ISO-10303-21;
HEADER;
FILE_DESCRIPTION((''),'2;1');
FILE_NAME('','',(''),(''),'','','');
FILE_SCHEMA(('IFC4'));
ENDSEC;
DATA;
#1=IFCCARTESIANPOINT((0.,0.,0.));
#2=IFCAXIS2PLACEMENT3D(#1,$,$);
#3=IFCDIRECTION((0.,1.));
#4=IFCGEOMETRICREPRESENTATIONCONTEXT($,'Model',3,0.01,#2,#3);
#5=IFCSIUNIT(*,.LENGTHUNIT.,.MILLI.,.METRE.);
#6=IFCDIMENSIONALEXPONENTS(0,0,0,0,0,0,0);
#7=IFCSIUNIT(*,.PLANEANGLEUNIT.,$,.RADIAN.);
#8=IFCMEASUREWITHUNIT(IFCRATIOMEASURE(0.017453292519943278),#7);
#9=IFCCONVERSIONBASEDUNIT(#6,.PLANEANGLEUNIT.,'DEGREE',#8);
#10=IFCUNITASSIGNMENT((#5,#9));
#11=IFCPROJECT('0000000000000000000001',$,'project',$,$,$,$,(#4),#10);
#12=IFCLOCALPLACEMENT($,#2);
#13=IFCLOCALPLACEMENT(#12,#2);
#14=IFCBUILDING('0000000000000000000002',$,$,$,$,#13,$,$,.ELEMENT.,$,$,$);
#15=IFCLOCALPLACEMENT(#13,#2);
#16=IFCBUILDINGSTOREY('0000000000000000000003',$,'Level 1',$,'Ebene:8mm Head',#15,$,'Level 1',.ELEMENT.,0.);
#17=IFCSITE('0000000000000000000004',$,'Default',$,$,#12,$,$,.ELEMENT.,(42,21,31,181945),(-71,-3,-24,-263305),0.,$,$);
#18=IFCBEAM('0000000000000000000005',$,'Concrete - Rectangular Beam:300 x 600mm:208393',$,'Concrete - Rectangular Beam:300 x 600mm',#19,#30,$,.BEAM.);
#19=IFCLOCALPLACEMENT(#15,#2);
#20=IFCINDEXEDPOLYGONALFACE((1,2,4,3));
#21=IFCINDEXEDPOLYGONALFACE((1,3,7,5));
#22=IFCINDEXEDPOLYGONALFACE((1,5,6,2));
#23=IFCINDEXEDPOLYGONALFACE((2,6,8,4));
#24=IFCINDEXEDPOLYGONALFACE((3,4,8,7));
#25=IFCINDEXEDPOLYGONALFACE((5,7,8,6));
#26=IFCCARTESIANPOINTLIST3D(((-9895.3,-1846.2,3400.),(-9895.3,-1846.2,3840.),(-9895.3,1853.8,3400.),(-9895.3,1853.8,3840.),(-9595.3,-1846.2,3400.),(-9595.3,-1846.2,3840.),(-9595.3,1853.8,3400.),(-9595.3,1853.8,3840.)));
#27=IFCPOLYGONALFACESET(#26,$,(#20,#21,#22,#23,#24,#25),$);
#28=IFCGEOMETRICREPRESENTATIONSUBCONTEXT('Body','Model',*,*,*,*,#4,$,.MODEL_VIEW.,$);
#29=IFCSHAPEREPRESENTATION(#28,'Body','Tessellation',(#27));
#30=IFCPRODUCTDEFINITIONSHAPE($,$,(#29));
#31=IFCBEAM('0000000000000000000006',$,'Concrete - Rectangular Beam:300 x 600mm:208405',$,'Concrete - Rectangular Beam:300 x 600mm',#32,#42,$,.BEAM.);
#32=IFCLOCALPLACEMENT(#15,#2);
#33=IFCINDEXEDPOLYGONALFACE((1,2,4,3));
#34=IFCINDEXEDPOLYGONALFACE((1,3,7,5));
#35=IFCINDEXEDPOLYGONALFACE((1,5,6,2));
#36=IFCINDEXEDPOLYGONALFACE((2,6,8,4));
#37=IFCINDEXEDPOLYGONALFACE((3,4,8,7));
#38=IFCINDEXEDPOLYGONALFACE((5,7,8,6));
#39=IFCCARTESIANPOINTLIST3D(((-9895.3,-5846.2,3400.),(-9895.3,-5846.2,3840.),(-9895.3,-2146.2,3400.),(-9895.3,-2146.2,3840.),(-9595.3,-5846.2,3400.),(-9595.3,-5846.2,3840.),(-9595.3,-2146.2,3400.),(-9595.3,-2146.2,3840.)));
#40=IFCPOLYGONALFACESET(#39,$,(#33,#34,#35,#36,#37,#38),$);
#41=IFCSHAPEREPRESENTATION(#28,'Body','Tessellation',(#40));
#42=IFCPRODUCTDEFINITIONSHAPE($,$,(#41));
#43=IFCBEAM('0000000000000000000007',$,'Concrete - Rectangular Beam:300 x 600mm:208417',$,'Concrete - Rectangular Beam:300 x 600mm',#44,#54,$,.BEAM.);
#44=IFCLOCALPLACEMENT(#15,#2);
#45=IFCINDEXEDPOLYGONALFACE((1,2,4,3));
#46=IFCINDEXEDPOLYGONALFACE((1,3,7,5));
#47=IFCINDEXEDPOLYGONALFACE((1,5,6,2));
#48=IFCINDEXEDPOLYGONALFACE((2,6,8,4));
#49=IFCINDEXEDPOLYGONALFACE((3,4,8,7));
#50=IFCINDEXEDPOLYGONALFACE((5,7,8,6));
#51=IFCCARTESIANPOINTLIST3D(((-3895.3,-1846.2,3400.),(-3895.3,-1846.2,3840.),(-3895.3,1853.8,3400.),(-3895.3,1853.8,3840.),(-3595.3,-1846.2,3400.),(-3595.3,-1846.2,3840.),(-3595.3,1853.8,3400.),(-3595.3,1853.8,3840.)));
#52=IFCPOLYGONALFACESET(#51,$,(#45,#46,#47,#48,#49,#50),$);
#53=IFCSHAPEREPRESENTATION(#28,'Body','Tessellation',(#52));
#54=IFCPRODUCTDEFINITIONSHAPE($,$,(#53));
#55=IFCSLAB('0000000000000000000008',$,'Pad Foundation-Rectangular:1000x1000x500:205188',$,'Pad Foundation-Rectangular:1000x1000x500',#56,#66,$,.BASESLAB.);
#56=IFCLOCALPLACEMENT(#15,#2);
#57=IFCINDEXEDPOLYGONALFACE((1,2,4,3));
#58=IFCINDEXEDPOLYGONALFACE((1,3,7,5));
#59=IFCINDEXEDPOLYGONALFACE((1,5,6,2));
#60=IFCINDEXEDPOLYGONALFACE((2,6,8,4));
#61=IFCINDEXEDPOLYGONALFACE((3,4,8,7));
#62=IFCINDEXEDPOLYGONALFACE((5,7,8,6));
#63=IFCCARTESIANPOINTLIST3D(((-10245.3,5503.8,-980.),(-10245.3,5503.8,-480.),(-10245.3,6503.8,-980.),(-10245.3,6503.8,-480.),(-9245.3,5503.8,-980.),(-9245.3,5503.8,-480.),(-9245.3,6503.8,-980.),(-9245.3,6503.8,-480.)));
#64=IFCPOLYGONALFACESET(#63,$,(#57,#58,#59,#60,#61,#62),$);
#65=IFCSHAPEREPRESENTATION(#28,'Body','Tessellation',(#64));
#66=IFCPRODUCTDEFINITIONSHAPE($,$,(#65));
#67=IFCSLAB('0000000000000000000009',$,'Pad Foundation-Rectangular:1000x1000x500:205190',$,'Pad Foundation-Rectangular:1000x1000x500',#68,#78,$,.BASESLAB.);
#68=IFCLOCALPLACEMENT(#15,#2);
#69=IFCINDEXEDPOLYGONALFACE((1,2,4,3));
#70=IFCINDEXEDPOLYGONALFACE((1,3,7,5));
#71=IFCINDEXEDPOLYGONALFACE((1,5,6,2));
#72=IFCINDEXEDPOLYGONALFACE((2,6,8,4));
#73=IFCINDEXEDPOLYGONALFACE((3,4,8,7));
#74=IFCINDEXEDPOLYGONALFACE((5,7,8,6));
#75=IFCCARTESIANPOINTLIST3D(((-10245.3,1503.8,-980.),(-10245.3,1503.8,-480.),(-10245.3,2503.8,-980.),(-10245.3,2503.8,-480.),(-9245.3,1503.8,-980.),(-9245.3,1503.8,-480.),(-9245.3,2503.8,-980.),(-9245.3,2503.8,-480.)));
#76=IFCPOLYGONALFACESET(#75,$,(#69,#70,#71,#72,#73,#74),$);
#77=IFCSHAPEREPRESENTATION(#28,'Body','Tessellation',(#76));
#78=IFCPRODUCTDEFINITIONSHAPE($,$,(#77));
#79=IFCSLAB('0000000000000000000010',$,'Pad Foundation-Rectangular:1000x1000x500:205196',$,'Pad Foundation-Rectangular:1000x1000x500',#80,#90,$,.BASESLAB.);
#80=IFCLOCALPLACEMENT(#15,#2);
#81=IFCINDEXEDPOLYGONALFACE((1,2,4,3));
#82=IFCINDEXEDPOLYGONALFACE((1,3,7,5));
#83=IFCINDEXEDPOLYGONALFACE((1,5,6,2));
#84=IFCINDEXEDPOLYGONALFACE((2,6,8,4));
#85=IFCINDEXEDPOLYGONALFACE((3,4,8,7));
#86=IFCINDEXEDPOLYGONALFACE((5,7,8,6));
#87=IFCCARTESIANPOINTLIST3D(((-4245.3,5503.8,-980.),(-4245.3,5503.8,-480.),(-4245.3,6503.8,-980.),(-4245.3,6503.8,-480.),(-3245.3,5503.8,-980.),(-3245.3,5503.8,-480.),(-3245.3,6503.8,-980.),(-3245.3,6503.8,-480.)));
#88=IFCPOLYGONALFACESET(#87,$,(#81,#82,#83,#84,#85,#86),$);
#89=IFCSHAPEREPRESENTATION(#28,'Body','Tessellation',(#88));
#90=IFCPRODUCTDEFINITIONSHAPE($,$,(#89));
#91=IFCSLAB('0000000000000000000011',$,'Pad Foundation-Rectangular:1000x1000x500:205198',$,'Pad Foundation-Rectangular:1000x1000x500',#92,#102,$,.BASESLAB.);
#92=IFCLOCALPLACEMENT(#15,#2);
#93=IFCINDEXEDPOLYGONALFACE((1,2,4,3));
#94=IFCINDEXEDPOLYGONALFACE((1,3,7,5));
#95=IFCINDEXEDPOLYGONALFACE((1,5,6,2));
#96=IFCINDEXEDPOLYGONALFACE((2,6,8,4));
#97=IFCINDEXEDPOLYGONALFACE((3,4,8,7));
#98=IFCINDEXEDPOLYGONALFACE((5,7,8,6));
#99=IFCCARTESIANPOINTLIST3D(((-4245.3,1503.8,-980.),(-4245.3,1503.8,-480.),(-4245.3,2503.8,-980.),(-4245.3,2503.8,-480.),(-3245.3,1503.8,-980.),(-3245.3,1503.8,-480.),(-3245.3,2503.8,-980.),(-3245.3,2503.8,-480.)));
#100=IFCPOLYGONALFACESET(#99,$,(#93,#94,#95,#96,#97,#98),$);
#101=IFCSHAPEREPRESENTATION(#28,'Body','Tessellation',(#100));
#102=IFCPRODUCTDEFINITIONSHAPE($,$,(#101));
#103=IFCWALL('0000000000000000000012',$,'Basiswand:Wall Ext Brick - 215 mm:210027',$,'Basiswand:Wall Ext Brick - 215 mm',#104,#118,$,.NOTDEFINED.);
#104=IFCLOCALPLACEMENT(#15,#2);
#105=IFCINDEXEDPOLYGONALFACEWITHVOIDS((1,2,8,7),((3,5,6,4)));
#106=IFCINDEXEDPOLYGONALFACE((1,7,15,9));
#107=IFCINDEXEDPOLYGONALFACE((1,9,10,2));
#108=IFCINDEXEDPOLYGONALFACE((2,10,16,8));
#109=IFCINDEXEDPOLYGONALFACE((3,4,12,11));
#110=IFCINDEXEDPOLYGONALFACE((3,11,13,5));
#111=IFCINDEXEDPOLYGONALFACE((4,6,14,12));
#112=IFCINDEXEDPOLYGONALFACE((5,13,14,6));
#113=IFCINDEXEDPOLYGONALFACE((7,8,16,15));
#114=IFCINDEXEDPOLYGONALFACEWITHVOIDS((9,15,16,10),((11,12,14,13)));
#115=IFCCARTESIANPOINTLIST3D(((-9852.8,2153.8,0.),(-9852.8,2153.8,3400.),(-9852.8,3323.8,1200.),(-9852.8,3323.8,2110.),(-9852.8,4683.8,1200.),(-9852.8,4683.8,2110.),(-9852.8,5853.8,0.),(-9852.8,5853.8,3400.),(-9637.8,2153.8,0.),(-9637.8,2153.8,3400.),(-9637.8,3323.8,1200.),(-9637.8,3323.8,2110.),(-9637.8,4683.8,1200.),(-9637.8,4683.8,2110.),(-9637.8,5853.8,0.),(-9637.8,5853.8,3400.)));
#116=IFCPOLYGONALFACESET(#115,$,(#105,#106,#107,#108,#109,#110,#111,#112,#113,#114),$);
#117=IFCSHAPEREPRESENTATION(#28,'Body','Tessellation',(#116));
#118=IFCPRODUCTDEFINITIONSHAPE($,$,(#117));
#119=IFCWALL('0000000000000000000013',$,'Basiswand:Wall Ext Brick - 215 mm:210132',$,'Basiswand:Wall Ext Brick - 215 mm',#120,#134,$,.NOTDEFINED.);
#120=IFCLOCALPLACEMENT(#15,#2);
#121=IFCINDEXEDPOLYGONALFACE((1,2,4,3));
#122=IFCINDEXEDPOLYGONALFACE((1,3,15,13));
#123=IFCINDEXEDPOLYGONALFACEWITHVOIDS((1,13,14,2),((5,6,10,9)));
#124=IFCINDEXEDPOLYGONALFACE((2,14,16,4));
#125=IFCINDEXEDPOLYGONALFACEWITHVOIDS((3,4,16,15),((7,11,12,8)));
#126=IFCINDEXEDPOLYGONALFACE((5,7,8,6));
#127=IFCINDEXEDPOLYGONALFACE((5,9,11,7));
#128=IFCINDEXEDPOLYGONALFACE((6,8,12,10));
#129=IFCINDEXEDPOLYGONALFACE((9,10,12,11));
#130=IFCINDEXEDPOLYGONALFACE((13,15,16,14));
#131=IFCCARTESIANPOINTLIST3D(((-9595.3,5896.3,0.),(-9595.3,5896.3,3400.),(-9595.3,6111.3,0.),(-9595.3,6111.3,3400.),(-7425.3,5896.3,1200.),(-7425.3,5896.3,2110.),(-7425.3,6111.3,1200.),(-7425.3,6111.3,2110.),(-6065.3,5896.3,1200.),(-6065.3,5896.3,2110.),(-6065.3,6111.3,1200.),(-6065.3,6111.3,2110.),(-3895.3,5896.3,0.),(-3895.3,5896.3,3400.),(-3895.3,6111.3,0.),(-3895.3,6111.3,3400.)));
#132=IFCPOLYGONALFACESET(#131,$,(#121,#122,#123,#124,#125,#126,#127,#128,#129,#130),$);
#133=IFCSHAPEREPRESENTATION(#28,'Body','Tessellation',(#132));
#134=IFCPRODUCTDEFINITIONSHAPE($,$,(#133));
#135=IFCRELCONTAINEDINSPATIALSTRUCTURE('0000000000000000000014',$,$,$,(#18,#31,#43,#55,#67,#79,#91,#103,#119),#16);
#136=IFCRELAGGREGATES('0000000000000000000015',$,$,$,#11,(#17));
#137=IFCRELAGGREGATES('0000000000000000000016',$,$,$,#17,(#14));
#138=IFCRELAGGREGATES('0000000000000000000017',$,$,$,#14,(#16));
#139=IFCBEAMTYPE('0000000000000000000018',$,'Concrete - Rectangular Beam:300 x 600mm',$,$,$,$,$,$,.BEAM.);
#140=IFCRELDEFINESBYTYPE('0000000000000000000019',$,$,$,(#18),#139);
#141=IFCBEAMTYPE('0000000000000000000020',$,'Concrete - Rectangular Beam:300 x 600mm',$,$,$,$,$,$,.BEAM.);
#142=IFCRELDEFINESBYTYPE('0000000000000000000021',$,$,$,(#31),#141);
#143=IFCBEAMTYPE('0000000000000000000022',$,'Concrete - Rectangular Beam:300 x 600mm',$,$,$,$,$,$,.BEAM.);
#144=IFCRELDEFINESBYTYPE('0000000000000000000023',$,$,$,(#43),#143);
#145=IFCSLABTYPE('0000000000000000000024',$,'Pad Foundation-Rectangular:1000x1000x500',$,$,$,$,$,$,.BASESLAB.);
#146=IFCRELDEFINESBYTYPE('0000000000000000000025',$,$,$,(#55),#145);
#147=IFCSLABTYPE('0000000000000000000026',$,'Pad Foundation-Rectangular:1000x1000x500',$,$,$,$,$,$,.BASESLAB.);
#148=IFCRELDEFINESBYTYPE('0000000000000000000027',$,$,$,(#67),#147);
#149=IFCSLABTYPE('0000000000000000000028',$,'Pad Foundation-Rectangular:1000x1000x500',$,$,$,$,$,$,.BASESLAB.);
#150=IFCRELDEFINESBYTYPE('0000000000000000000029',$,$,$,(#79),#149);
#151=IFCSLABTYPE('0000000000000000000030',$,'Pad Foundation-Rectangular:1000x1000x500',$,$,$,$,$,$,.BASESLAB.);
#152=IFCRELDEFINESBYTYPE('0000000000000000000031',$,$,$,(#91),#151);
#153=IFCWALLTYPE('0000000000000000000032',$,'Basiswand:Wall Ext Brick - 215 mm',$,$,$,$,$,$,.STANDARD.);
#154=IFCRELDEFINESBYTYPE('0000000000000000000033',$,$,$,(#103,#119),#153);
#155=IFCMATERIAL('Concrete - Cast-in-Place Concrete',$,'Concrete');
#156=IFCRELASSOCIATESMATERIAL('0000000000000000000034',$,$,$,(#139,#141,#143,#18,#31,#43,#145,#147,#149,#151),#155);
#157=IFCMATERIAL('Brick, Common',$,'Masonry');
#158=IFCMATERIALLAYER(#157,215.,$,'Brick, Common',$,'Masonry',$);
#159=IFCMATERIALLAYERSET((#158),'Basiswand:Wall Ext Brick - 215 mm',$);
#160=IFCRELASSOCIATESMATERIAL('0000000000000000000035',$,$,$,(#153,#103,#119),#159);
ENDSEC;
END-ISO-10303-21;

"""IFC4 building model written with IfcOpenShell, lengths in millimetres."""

from ifc_helpers import new_model, entity, si_unit, converted_unit, direction, frame, frame_2d, origin, origin_2d_with_axis, place, context, subcontext, project, spatial, polyline, segment, composite_curve, rectangle, outline, extrude, source, transform, mapped, material, layer, layer_set, layer_usage, material_profile, profile_set, profile_usage, type_object, type_shapes, element, save


model = new_model("IFC4")

# Units and contexts
model_context = context("Model", 3, precision=0.01, world=origin(), true_north=direction((0.0, 1.0)))
body_context = subcontext(model_context, "Body", "Model", "MODEL_VIEW")
ifc_project = project(units=[si_unit("LENGTHUNIT", "METRE", prefix="MILLI"), converted_unit("PLANEANGLEUNIT", "DEGREE", entity("IfcRatioMeasure", 0.017453292519943278), si_unit("PLANEANGLEUNIT", "RADIAN"), dimensions=[0, 0, 0, 0, 0, 0, 0])], contexts=[model_context])

# Site, building, storey
site_placement = place(None, origin())
site = spatial("IfcSite", under=ifc_project, at=site_placement, Name="Default", CompositionType="ELEMENT", RefLatitude=(42, 21, 31, 181945), RefLongitude=(-71, -3, -24, -263305), RefElevation=0.0)
building_placement = place(site_placement, origin())
building = spatial("IfcBuilding", under=site, at=building_placement, CompositionType="ELEMENT")
storey_placement = place(building_placement, origin())
storey = spatial("IfcBuildingStorey", under=building, at=storey_placement, Name="Level 1", ObjectType="Ebene:8mm Head", LongName="Level 1", CompositionType="ELEMENT", Elevation=0.0)

# Shared definitions
ifc_material_1 = material(Name="Concrete - Cast-in-Place Concrete", Category="Concrete")

# Beams
ifc_material_profile_1 = material_profile(ifc_material_1, outline(composite_curve([segment(polyline([(-150.0, -300.0, 0.0), (-150.0, 140.0, 0.0)]), True, "CONTINUOUS"), segment(polyline([(-150.0, 140.0, 0.0), (150.0, 140.0, 0.0)]), True, "CONTINUOUS"), segment(polyline([(150.0, 140.0, 0.0), (150.0, -300.0, 0.0)]), True, "CONTINUOUS"), segment(polyline([(150.0, -300.0, 0.0), (-150.0, -300.0, 0.0)]), True, "CONTINUOUS")], self_intersect=False), kind="CURVE"), Name="300 x 600mm")
ifc_material_profile_2 = material_profile(ifc_material_1, outline(composite_curve([segment(polyline([(1850.0, -150.0, -300.0), (1850.0, -150.0, 300.0)]), True, "CONTINUOUS"), segment(polyline([(1850.0, -150.0, 300.0), (-1850.0, -150.0, 300.0)]), True, "CONTINUOUS"), segment(polyline([(-1850.0, -150.0, 300.0), (-1850.0, -150.0, -300.0)]), True, "CONTINUOUS"), segment(polyline([(-1850.0, -150.0, -300.0), (1850.0, -150.0, -300.0)]), True, "CONTINUOUS")], self_intersect=False), kind="CURVE"), Name="300 x 600mm")
ifc_profile_set_1 = profile_set([ifc_material_profile_1, ifc_material_profile_2], Name="300 x 600mm")
ifc_profile_usage_1 = profile_usage(ifc_profile_set_1, cardinal=8)
beam_type_1 = type_object("IfcBeamType", Name="Concrete - Rectangular Beam:300 x 600mm", PredefinedType="BEAM", material=ifc_profile_set_1)
shared_shape_1 = source(origin(), body_context, "Body", "SweptSolid", [
    extrude(rectangle(XDim=440.0, YDim=300.0, at=frame_2d((0.0, 0.0), x_axis=(0.0, 1.0))), frame((-9745.3, 1853.8, 3620.0), z_axis=(0.0, -1.0, 0.0), x_axis=(-1.0, 0.0, 0.0)), (0.0, 0.0, 1.0), 3700.0),
])
type_shapes(beam_type_1, [shared_shape_1])
beam_1_placement = place(storey_placement, origin())
element("IfcBeam", 1, at=beam_1_placement, inside=storey, type_object=beam_type_1, material=ifc_profile_usage_1, Name="Concrete - Rectangular Beam:300 x 600mm:208393", ObjectType="Concrete - Rectangular Beam:300 x 600mm", PredefinedType="BEAM", context=body_context, shape_type="MappedRepresentation", body=[
    mapped(shared_shape_1, transform((0.0, 0.0, 0.0), scale=1.0)),
])
ifc_profile_usage_2 = profile_usage(ifc_profile_set_1, cardinal=8)
beam_type_2 = type_object("IfcBeamType", Name="Concrete - Rectangular Beam:300 x 600mm", PredefinedType="BEAM", material=ifc_profile_set_1)
shared_shape_2 = source(origin(), body_context, "Body", "SweptSolid", [
    extrude(rectangle(XDim=440.0, YDim=300.0, at=frame_2d((0.0, 0.0), x_axis=(0.0, 1.0))), frame((-9745.3, -2146.2, 3620.0), z_axis=(0.0, -1.0, 0.0), x_axis=(-1.0, 0.0, 0.0)), (0.0, 0.0, 1.0), 3700.0),
])
type_shapes(beam_type_2, [shared_shape_2])
beam_2_placement = place(storey_placement, origin())
element("IfcBeam", 2, at=beam_2_placement, inside=storey, type_object=beam_type_2, material=ifc_profile_usage_2, Name="Concrete - Rectangular Beam:300 x 600mm:208405", ObjectType="Concrete - Rectangular Beam:300 x 600mm", PredefinedType="BEAM", context=body_context, shape_type="MappedRepresentation", body=[
    mapped(shared_shape_2, transform((0.0, 0.0, 0.0), scale=1.0)),
])
ifc_profile_usage_3 = profile_usage(ifc_profile_set_1, cardinal=8)
beam_type_3 = type_object("IfcBeamType", Name="Concrete - Rectangular Beam:300 x 600mm", PredefinedType="BEAM", material=ifc_profile_set_1)
shared_shape_3 = source(origin(), body_context, "Body", "SweptSolid", [
    extrude(rectangle(XDim=440.0, YDim=300.0, at=frame_2d((0.0, 0.0), x_axis=(0.0, 1.0))), frame((-3745.3, 1853.8, 3620.0), z_axis=(0.0, -1.0, 0.0), x_axis=(-1.0, 0.0, 0.0)), (0.0, 0.0, 1.0), 3700.0),
])
type_shapes(beam_type_3, [shared_shape_3])
beam_3_placement = place(storey_placement, origin())
element("IfcBeam", 3, at=beam_3_placement, inside=storey, type_object=beam_type_3, material=ifc_profile_usage_3, Name="Concrete - Rectangular Beam:300 x 600mm:208417", ObjectType="Concrete - Rectangular Beam:300 x 600mm", PredefinedType="BEAM", context=body_context, shape_type="MappedRepresentation", body=[
    mapped(shared_shape_3, transform((0.0, 0.0, 0.0), scale=1.0)),
])

# Slabs
slab_type_1 = type_object("IfcSlabType", Name="Pad Foundation-Rectangular:1000x1000x500", PredefinedType="BASESLAB", material=ifc_material_1)
slab_1_placement = place(storey_placement, frame((-10245.3, 5503.8, -980.0)))
element("IfcSlab", 4, at=slab_1_placement, inside=storey, type_object=slab_type_1, Name="Pad Foundation-Rectangular:1000x1000x500:205188", ObjectType="Pad Foundation-Rectangular:1000x1000x500", PredefinedType="BASESLAB", context=body_context, shape_type="SweptSolid", body=[
    extrude(rectangle(XDim=1000.0, YDim=1000.0, at=frame_2d((0.0, 0.0), x_axis=(1.0, 0.0))), frame((500.0, 500.0, 0.0), z_axis=(0.0, 0.0, 1.0), x_axis=(-1.0, 0.0, 0.0)), (0.0, 0.0, 1.0), 500.0),
])
slab_type_2 = type_object("IfcSlabType", Name="Pad Foundation-Rectangular:1000x1000x500", PredefinedType="BASESLAB", material=ifc_material_1)
slab_2_placement = place(storey_placement, frame((-10245.3, 1503.8, -980.0)))
element("IfcSlab", 5, at=slab_2_placement, inside=storey, type_object=slab_type_2, Name="Pad Foundation-Rectangular:1000x1000x500:205190", ObjectType="Pad Foundation-Rectangular:1000x1000x500", PredefinedType="BASESLAB", context=body_context, shape_type="SweptSolid", body=[
    extrude(rectangle(XDim=1000.0, YDim=1000.0, at=frame_2d((0.0, 0.0), x_axis=(1.0, 0.0))), frame((500.0, 500.0, 0.0), z_axis=(0.0, 0.0, 1.0), x_axis=(-1.0, 0.0, 0.0)), (0.0, 0.0, 1.0), 500.0),
])
slab_type_3 = type_object("IfcSlabType", Name="Pad Foundation-Rectangular:1000x1000x500", PredefinedType="BASESLAB", material=ifc_material_1)
slab_3_placement = place(storey_placement, frame((-4245.3, 5503.8, -980.0)))
element("IfcSlab", 6, at=slab_3_placement, inside=storey, type_object=slab_type_3, Name="Pad Foundation-Rectangular:1000x1000x500:205196", ObjectType="Pad Foundation-Rectangular:1000x1000x500", PredefinedType="BASESLAB", context=body_context, shape_type="SweptSolid", body=[
    extrude(rectangle(XDim=1000.0, YDim=1000.0, at=frame_2d((0.0, 0.0), x_axis=(1.0, 0.0))), frame((500.0, 500.0, 0.0), z_axis=(0.0, 0.0, 1.0), x_axis=(-1.0, 0.0, 0.0)), (0.0, 0.0, 1.0), 500.0),
])
slab_type_4 = type_object("IfcSlabType", Name="Pad Foundation-Rectangular:1000x1000x500", PredefinedType="BASESLAB", material=ifc_material_1)
slab_4_placement = place(storey_placement, frame((-4245.3, 1503.8, -980.0)))
element("IfcSlab", 7, at=slab_4_placement, inside=storey, type_object=slab_type_4, Name="Pad Foundation-Rectangular:1000x1000x500:205198", ObjectType="Pad Foundation-Rectangular:1000x1000x500", PredefinedType="BASESLAB", context=body_context, shape_type="SweptSolid", body=[
    extrude(rectangle(XDim=1000.0, YDim=1000.0, at=origin_2d_with_axis()), frame((500.0, 500.0, 0.0), z_axis=(0.0, 0.0, 1.0), x_axis=(-1.0, 0.0, 0.0)), (0.0, 0.0, 1.0), 500.0),
])

# Walls, openings
ifc_material_2 = material(Name="Brick, Common", Category="Masonry")
ifc_layer_1 = layer(ifc_material_2, 215.0, Name="Brick, Common", Category="Masonry")
ifc_layer_set_1 = layer_set([ifc_layer_1], Name="Basiswand:Wall Ext Brick - 215 mm")
ifc_layer_usage_1 = layer_usage(ifc_layer_set_1, "AXIS2", "NEGATIVE", 107.5)
wall_type_1 = type_object("IfcWallType", Name="Basiswand:Wall Ext Brick - 215 mm", PredefinedType="STANDARD", material=ifc_layer_set_1)
wall_1_placement = place(storey_placement, frame((-9745.3, 2153.8, 0.0), z_axis=(0.0, 0.0, 1.0), x_axis=(0.0, 1.0, 0.0)))
wall_1 = element("IfcWall", 8, at=wall_1_placement, inside=storey, type_object=wall_type_1, material=ifc_layer_usage_1, Name="Basiswand:Wall Ext Brick - 215 mm:210027", ObjectType="Basiswand:Wall Ext Brick - 215 mm", PredefinedType="NOTDEFINED", context=body_context, shape_type="SweptSolid", body=[
    extrude(rectangle(XDim=3700.0, YDim=215.0, at=frame_2d((1850.0, 0.0), x_axis=(-1.0, 0.0))), origin(), (0.0, 0.0, 1.0), 3400.0),
])
opening_1_placement = place(wall_1_placement, frame((2530.0, 107.5, 1200.0)))
element("IfcOpeningElement", 9, at=opening_1_placement, cuts=wall_1, PredefinedType="OPENING", context=body_context, shape_type="SweptSolid", body=[
    extrude(rectangle(XDim=910.0, YDim=1360.0, at=frame_2d((455.0, 680.0), x_axis=(-1.0, 0.0))), frame((0.0, 0.0, 0.0), z_axis=(0.0, -1.0, 0.0), x_axis=(0.0, 0.0, 1.0)), (0.0, 0.0, 1.0), 215.0),
])
ifc_layer_usage_2 = layer_usage(ifc_layer_set_1, "AXIS2", "NEGATIVE", 107.5)
wall_2_placement = place(storey_placement, frame((-9595.3, 6003.8, 0.0)))
wall_2 = element("IfcWall", 10, at=wall_2_placement, inside=storey, type_object=wall_type_1, material=ifc_layer_usage_2, Name="Basiswand:Wall Ext Brick - 215 mm:210132", ObjectType="Basiswand:Wall Ext Brick - 215 mm", PredefinedType="NOTDEFINED", context=body_context, shape_type="SweptSolid", body=[
    extrude(rectangle(XDim=5700.0, YDim=215.0, at=frame_2d((2850.0, 0.0), x_axis=(-1.0, 0.0))), origin(), (0.0, 0.0, 1.0), 3400.0),
])
opening_2_placement = place(wall_2_placement, frame((2170.0, -107.5, 1200.0)))
element("IfcOpeningElement", 11, at=opening_2_placement, cuts=wall_2, PredefinedType="OPENING", context=body_context, shape_type="SweptSolid", body=[
    extrude(rectangle(XDim=910.0, YDim=1360.0, at=frame_2d((455.0, 680.0), x_axis=(-1.0, 0.0))), frame((0.0, 0.0, 0.0), z_axis=(0.0, 1.0, 0.0), x_axis=(0.0, 0.0, 1.0)), (0.0, 0.0, 1.0), 215.0),
])

save(model, "model.ifc")
